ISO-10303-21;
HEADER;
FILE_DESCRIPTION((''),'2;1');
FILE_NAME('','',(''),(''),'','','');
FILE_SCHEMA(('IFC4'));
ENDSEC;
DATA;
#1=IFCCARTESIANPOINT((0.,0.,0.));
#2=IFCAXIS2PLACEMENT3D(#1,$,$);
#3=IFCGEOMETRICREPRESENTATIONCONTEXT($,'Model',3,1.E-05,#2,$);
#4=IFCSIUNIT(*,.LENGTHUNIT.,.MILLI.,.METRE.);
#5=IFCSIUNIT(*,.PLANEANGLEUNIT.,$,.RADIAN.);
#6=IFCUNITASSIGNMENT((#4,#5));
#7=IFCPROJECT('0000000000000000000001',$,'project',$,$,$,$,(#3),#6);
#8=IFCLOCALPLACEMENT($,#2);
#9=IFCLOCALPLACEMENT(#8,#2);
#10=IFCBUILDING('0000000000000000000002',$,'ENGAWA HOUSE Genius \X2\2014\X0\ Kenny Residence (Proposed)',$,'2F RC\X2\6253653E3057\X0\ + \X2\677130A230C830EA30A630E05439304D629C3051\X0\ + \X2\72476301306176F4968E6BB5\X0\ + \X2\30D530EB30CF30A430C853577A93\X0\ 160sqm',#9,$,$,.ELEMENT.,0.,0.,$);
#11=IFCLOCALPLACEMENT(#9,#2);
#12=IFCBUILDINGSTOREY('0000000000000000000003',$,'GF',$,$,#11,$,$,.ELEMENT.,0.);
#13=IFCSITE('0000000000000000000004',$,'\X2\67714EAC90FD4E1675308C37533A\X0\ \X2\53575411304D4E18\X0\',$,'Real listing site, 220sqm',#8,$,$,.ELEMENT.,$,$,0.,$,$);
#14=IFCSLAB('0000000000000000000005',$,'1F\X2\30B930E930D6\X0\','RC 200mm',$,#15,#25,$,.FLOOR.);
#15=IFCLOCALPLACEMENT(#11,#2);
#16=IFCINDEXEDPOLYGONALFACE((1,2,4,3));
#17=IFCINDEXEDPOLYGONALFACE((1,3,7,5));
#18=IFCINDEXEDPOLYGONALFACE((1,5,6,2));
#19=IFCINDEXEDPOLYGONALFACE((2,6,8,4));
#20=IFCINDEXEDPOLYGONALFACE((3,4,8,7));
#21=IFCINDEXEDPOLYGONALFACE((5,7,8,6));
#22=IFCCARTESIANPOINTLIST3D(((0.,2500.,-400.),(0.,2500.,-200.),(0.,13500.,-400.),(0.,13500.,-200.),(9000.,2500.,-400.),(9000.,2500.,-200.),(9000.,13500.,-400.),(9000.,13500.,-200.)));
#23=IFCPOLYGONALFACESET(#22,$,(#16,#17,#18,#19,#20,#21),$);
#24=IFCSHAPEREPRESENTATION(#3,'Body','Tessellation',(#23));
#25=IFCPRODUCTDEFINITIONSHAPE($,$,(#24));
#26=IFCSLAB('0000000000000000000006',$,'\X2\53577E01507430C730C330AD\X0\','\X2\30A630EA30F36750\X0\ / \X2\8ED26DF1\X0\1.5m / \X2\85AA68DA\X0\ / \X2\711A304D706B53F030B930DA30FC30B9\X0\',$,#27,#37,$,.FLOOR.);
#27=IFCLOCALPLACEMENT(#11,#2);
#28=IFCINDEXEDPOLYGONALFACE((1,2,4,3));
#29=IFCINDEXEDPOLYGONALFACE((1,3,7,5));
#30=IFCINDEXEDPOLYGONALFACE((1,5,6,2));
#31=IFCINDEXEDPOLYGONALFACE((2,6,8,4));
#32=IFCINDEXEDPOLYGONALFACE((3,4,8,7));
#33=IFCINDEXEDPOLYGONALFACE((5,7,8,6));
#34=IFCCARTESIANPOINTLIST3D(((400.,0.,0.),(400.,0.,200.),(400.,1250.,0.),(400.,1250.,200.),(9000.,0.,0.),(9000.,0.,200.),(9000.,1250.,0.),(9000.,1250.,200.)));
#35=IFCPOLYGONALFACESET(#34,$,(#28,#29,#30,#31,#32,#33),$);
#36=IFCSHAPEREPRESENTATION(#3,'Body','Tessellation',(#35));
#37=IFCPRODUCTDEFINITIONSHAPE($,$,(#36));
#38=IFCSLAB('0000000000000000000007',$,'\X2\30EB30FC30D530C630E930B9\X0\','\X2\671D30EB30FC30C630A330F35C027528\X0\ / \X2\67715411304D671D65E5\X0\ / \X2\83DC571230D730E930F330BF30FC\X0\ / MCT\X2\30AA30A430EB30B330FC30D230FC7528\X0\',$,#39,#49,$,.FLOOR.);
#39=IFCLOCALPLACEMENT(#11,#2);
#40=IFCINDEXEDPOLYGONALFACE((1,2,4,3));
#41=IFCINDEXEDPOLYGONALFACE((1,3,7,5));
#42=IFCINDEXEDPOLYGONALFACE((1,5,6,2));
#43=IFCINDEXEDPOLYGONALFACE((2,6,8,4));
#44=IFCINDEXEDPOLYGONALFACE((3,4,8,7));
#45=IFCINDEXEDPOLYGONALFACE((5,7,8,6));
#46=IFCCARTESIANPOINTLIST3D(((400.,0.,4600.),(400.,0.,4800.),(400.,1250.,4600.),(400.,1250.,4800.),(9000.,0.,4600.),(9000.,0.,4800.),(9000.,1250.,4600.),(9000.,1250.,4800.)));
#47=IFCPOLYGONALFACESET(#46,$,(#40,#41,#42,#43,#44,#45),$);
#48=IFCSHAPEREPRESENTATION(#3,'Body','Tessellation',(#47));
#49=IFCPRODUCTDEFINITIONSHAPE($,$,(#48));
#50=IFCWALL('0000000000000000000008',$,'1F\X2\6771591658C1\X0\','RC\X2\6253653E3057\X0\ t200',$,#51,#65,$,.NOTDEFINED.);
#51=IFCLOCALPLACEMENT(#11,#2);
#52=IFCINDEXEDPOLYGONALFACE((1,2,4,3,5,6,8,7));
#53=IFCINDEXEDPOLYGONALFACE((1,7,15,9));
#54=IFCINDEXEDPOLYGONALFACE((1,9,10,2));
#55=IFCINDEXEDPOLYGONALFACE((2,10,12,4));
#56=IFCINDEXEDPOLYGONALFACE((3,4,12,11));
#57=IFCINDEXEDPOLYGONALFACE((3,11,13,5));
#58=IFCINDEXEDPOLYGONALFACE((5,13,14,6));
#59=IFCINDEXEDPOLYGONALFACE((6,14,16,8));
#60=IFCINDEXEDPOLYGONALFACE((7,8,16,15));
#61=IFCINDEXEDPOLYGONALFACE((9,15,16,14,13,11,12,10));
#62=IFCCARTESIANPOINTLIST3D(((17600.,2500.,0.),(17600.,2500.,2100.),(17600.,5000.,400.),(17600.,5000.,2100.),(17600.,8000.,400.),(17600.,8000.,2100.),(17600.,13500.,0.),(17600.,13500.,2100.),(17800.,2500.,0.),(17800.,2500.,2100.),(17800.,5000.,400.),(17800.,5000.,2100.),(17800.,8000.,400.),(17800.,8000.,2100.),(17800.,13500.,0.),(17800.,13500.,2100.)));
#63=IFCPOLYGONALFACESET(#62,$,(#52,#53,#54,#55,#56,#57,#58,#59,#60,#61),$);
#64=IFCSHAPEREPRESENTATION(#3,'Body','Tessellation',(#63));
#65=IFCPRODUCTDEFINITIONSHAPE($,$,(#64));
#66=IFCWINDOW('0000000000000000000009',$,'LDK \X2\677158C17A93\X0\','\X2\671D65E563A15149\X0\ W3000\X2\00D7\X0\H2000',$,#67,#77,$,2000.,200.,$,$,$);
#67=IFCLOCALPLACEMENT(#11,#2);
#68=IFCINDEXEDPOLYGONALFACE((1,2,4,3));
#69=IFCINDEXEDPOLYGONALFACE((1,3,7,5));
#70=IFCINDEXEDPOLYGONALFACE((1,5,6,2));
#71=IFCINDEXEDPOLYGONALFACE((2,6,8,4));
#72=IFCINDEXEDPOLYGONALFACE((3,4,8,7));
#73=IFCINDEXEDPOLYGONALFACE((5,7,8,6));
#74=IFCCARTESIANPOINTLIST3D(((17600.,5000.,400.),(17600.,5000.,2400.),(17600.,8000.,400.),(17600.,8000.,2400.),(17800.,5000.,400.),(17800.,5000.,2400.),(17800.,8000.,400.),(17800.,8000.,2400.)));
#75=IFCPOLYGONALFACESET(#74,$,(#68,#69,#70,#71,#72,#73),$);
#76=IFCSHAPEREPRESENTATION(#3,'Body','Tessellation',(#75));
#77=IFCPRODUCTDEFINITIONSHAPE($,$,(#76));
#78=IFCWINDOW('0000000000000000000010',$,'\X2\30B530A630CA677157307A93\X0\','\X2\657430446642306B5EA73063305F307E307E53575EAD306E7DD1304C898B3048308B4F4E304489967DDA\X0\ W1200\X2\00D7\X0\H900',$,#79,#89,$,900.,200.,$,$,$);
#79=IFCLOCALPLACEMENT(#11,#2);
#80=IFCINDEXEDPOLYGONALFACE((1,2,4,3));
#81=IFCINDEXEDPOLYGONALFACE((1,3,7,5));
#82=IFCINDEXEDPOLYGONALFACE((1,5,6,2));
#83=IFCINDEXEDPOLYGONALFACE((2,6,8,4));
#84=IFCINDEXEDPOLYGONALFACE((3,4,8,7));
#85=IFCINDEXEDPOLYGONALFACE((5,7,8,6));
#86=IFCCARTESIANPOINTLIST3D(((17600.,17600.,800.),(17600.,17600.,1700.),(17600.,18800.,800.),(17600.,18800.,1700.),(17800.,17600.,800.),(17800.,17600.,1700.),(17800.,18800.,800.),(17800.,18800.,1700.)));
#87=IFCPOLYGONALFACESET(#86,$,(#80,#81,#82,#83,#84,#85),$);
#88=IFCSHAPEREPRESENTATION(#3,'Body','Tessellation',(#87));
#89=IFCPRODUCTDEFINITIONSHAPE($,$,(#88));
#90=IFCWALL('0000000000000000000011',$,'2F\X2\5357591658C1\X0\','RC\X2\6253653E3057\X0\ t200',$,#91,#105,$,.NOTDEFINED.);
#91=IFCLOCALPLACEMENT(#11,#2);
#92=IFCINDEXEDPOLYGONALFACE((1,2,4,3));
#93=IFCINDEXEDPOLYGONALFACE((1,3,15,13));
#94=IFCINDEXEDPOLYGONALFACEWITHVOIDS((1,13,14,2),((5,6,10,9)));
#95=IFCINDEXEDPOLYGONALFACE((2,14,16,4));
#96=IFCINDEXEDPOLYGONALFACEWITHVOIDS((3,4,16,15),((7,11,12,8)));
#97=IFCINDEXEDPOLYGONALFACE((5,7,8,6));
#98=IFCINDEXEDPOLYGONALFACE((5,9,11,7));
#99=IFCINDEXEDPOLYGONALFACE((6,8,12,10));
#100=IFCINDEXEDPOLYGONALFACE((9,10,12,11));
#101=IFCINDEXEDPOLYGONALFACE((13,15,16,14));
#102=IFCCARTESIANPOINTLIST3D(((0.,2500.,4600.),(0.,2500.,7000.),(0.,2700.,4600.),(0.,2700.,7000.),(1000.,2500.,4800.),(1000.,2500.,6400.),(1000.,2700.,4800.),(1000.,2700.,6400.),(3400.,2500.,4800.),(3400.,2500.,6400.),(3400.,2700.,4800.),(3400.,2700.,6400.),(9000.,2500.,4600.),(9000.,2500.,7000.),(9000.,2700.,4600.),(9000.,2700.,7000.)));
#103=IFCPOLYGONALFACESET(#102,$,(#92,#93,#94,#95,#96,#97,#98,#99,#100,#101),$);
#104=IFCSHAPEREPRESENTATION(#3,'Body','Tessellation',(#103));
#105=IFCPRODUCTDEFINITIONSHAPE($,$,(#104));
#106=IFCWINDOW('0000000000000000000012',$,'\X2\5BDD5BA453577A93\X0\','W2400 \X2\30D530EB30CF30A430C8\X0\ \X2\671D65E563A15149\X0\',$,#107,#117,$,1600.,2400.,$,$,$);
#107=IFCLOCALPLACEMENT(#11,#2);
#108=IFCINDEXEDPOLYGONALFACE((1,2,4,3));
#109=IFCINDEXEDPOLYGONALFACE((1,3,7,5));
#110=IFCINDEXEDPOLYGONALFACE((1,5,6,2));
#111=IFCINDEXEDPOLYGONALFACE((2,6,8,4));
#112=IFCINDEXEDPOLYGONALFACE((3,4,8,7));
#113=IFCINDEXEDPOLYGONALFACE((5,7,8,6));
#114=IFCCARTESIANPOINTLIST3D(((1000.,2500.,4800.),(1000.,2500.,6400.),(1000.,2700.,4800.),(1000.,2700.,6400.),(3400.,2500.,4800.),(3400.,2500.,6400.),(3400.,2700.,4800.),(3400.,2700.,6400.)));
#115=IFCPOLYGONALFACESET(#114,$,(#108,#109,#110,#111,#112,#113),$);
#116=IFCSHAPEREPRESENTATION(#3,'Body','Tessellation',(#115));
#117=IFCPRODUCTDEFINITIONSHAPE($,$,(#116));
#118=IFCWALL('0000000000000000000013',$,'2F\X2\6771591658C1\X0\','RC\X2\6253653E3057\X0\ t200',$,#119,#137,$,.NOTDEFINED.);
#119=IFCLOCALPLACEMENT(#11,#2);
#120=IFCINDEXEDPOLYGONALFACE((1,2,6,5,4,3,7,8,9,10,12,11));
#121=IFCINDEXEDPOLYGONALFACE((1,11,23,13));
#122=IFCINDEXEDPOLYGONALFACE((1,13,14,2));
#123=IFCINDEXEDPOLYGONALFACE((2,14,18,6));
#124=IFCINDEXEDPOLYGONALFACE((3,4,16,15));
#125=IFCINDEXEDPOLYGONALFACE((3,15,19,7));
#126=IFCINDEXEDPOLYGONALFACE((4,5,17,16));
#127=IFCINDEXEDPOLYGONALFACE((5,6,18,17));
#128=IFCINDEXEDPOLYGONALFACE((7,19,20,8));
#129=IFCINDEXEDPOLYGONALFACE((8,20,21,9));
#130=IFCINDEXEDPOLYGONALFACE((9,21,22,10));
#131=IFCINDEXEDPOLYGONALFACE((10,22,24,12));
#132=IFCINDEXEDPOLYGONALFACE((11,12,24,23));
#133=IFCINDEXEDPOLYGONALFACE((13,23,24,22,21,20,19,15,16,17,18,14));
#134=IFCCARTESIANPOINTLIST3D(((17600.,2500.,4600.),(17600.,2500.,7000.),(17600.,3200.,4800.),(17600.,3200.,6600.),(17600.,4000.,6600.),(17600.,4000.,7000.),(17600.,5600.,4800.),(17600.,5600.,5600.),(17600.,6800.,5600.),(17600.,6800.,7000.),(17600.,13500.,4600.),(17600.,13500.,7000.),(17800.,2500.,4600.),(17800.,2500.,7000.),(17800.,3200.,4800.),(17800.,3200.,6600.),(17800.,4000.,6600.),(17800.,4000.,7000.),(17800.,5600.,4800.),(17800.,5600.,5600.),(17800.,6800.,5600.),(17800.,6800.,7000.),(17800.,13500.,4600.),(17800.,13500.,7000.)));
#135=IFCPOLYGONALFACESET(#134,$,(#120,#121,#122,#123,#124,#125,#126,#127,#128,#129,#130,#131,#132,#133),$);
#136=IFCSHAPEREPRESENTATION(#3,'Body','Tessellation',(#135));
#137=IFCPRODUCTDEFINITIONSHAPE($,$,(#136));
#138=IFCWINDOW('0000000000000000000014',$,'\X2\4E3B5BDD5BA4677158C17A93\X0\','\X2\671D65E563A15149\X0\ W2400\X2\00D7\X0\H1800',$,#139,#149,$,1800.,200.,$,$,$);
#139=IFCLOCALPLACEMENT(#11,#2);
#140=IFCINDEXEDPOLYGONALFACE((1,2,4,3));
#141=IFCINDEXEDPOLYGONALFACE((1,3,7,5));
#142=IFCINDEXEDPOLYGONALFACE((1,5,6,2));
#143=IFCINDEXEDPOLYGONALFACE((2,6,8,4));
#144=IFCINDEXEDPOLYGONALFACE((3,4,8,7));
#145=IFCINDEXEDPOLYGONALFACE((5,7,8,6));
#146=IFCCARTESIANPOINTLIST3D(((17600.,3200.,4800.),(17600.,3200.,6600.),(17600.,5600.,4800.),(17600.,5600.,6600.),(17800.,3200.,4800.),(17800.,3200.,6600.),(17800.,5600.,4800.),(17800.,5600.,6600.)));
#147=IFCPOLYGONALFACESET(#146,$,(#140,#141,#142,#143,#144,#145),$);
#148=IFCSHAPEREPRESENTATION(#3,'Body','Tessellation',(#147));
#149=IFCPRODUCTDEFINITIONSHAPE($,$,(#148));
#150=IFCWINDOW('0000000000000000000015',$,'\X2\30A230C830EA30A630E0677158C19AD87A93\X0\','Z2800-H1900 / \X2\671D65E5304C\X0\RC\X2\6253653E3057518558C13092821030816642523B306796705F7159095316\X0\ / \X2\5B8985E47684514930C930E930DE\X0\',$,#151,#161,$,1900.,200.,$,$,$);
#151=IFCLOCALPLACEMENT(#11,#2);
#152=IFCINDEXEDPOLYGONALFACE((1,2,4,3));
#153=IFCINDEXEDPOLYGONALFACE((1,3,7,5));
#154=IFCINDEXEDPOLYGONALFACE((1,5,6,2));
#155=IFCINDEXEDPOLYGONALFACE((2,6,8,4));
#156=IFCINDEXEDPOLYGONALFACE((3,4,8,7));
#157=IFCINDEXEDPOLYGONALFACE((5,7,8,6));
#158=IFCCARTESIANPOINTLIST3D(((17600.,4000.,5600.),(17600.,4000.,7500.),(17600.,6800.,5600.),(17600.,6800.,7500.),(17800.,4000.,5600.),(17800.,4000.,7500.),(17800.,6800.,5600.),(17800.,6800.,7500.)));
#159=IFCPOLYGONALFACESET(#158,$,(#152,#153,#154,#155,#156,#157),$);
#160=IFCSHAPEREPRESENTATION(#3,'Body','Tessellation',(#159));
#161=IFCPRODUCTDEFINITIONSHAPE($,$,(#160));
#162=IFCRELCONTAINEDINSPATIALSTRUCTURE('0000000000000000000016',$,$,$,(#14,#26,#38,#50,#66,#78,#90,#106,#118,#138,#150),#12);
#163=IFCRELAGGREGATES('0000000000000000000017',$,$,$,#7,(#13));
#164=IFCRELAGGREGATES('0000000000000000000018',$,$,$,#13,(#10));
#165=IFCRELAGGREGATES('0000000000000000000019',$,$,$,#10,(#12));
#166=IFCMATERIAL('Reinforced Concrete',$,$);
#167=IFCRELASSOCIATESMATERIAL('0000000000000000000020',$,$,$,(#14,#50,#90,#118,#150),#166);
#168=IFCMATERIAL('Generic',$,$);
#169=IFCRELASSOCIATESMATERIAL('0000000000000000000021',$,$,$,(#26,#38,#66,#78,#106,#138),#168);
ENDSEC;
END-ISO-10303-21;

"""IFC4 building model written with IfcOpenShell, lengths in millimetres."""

from ifc_helpers import new_model, si_unit, frame, frame_2d, origin, place, context, project, spatial, rectangle, extrude, material, element, fill, save


model = new_model("IFC4")

# Units and contexts
model_context = context("Model", 3, precision=1e-05, world=origin())
ifc_project = project(units=[si_unit("LENGTHUNIT", "METRE", prefix="MILLI"), si_unit("PLANEANGLEUNIT", "RADIAN")], contexts=[model_context])

# Site, building, storey
site_placement = place(None, origin())
site = spatial("IfcSite", under=ifc_project, at=site_placement, Name="東京都世田谷区 南向き丘", ObjectType="Real listing site, 220sqm", CompositionType="ELEMENT", RefElevation=0.0)
building_placement = place(site_placement, origin())
building = spatial("IfcBuilding", under=site, at=building_placement, Name="ENGAWA HOUSE Genius — Kenny Residence (Proposed)", ObjectType="2F RC打放し + 東アトリウム吹き抜け + 片持ち直階段 + フルハイト南窓 160sqm", CompositionType="ELEMENT", ElevationOfRefHeight=0.0, ElevationOfTerrain=0.0)
storey_placement = place(building_placement, origin())
storey = spatial("IfcBuildingStorey", under=building, at=storey_placement, Name="GF", CompositionType="ELEMENT", Elevation=0.0)

# Slabs
ifc_material_1 = material(Name="Reinforced Concrete")
slab_1_placement = place(storey_placement, frame((0.0, 1250.0, -200.0)))
element("IfcSlab", 1, at=slab_1_placement, inside=storey, material=ifc_material_1, Name="1Fスラブ", Description="RC 200mm", PredefinedType="FLOOR", context=model_context, shape_type="SweptSolid", body=[
    extrude(rectangle(XDim=9000.0, YDim=11000.0, at=frame_2d((4500.0, 5500.0))), frame((0.0, 1250.0, -200.0)), (0.0, 0.0, 1.0), 200.0),
])
ifc_material_2 = material(Name="Generic")
slab_2_placement = place(storey_placement, frame((200.0, 0.0, 0.0)))
element("IfcSlab", 2, at=slab_2_placement, inside=storey, material=ifc_material_2, Name="南縁側デッキ", Description="ウリン材 / 軒深1.5m / 薪棚 / 焚き火台スペース", PredefinedType="FLOOR", context=model_context, shape_type="SweptSolid", body=[
    extrude(rectangle(XDim=8600.0, YDim=1250.0, at=frame_2d((4300.0, 625.0))), frame((200.0, 0.0, 0.0)), (0.0, 0.0, 1.0), 200.0),
])
slab_3_placement = place(storey_placement, frame((200.0, 0.0, 2300.0)))
element("IfcSlab", 3, at=slab_3_placement, inside=storey, material=ifc_material_2, Name="ルーフテラス", Description="朝ルーティン専用 / 東向き朝日 / 菜園プランター / MCTオイルコーヒー用", PredefinedType="FLOOR", context=model_context, shape_type="SweptSolid", body=[
    extrude(rectangle(XDim=8600.0, YDim=1250.0, at=frame_2d((4300.0, 625.0))), frame((200.0, 0.0, 2300.0)), (0.0, 0.0, 1.0), 200.0),
])

# Wall, openings, windows
wall_1_placement = place(storey_placement, frame((8800.0, 1250.0, 0.0)))
wall_1 = element("IfcWall", 4, at=wall_1_placement, inside=storey, material=ifc_material_1, Name="1F東外壁", Description="RC打放し t200", PredefinedType="NOTDEFINED", context=model_context, shape_type="SweptSolid", body=[
    extrude(rectangle(XDim=200.0, YDim=11000.0, at=frame_2d((100.0, 5500.0))), frame((8800.0, 1250.0, 0.0)), (0.0, 0.0, 1.0), 2100.0),
])
opening_1_placement = place(storey_placement, frame((8800.0, 2500.0, 200.0)))
opening_1 = element("IfcOpeningElement", 5, at=opening_1_placement, cuts=wall_1, PredefinedType="NOTDEFINED", context=model_context, shape_type="SweptSolid", body=[
    extrude(rectangle(XDim=200.0, YDim=3000.0, at=frame_2d((100.0, 1500.0))), frame((8800.0, 2500.0, 200.0)), (0.0, 0.0, 1.0), 2000.0),
])
opening_2_placement = place(storey_placement, frame((8800.0, 8800.0, 400.0)))
opening_2 = element("IfcOpeningElement", 6, at=opening_2_placement, cuts=wall_1, PredefinedType="NOTDEFINED", context=model_context, shape_type="SweptSolid", body=[
    extrude(rectangle(XDim=200.0, YDim=1200.0, at=frame_2d((100.0, 600.0))), frame((8800.0, 8800.0, 400.0)), (0.0, 0.0, 1.0), 900.0),
])
window_1_placement = place(storey_placement, frame((8800.0, 2500.0, 200.0)))
window_1 = element("IfcWindow", 7, at=window_1_placement, inside=storey, material=ifc_material_2, Name="LDK 東壁窓", Description="朝日採光 W3000×H2000", OverallHeight=2000.0, OverallWidth=200.0, context=model_context, shape_type="SweptSolid", body=[
    extrude(rectangle(XDim=200.0, YDim=3000.0, at=frame_2d((100.0, 1500.0))), frame((8800.0, 2500.0, 200.0)), (0.0, 0.0, 1.0), 2000.0),
])
fill(opening_1, window_1)
window_2_placement = place(storey_placement, frame((8800.0, 8800.0, 400.0)))
window_2 = element("IfcWindow", 8, at=window_2_placement, inside=storey, material=ifc_material_2, Name="サウナ東地窓", Description="整い時に座ったまま南庭の緑が見える低い視線 W1200×H900", OverallHeight=900.0, OverallWidth=200.0, context=model_context, shape_type="SweptSolid", body=[
    extrude(rectangle(XDim=200.0, YDim=1200.0, at=frame_2d((100.0, 600.0))), frame((8800.0, 8800.0, 400.0)), (0.0, 0.0, 1.0), 900.0),
])
fill(opening_2, window_2)

# Wall, opening, window
wall_2_placement = place(storey_placement, frame((0.0, 1250.0, 2300.0)))
wall_2 = element("IfcWall", 9, at=wall_2_placement, inside=storey, material=ifc_material_1, Name="2F南外壁", Description="RC打放し t200", PredefinedType="NOTDEFINED", context=model_context, shape_type="SweptSolid", body=[
    extrude(rectangle(XDim=9000.0, YDim=200.0, at=frame_2d((4500.0, 100.0))), frame((0.0, 1250.0, 2300.0)), (0.0, 0.0, 1.0), 2400.0),
])
opening_3_placement = place(storey_placement, frame((500.0, 1250.0, 2400.0)))
opening_3 = element("IfcOpeningElement", 10, at=opening_3_placement, cuts=wall_2, PredefinedType="NOTDEFINED", context=model_context, shape_type="SweptSolid", body=[
    extrude(rectangle(XDim=2400.0, YDim=200.0, at=frame_2d((1200.0, 100.0))), frame((500.0, 1250.0, 2400.0)), (0.0, 0.0, 1.0), 1600.0),
])
window_3_placement = place(storey_placement, frame((500.0, 1250.0, 2400.0)))
window_3 = element("IfcWindow", 11, at=window_3_placement, inside=storey, material=ifc_material_2, Name="寝室南窓", Description="W2400 フルハイト 朝日採光", OverallHeight=1600.0, OverallWidth=2400.0, context=model_context, shape_type="SweptSolid", body=[
    extrude(rectangle(XDim=2400.0, YDim=200.0, at=frame_2d((1200.0, 100.0))), frame((500.0, 1250.0, 2400.0)), (0.0, 0.0, 1.0), 1600.0),
])
fill(opening_3, window_3)

# Wall, openings, windows
wall_3_placement = place(storey_placement, frame((8800.0, 1250.0, 2300.0)))
wall_3 = element("IfcWall", 12, at=wall_3_placement, inside=storey, material=ifc_material_1, Name="2F東外壁", Description="RC打放し t200", PredefinedType="NOTDEFINED", context=model_context, shape_type="SweptSolid", body=[
    extrude(rectangle(XDim=200.0, YDim=11000.0, at=frame_2d((100.0, 5500.0))), frame((8800.0, 1250.0, 2300.0)), (0.0, 0.0, 1.0), 2400.0),
])
opening_4_placement = place(storey_placement, frame((8800.0, 1600.0, 2400.0)))
opening_4 = element("IfcOpeningElement", 13, at=opening_4_placement, cuts=wall_3, PredefinedType="NOTDEFINED", context=model_context, shape_type="SweptSolid", body=[
    extrude(rectangle(XDim=200.0, YDim=2400.0, at=frame_2d((100.0, 1200.0))), frame((8800.0, 1600.0, 2400.0)), (0.0, 0.0, 1.0), 1800.0),
])
opening_5_placement = place(storey_placement, frame((8800.0, 2000.0, 2800.0)))
opening_5 = element("IfcOpeningElement", 14, at=opening_5_placement, cuts=wall_3, PredefinedType="NOTDEFINED", context=model_context, shape_type="SweptSolid", body=[
    extrude(rectangle(XDim=200.0, YDim=2800.0, at=frame_2d((100.0, 1400.0))), frame((8800.0, 2000.0, 2800.0)), (0.0, 0.0, 1.0), 1900.0),
])
window_4_placement = place(storey_placement, frame((8800.0, 1600.0, 2400.0)))
window_4 = element("IfcWindow", 15, at=window_4_placement, inside=storey, material=ifc_material_2, Name="主寝室東壁窓", Description="朝日採光 W2400×H1800", OverallHeight=1800.0, OverallWidth=200.0, context=model_context, shape_type="SweptSolid", body=[
    extrude(rectangle(XDim=200.0, YDim=2400.0, at=frame_2d((100.0, 1200.0))), frame((8800.0, 1600.0, 2400.0)), (0.0, 0.0, 1.0), 1800.0),
])
fill(opening_4, window_4)
window_5_placement = place(storey_placement, frame((8800.0, 2000.0, 2800.0)))
window_5 = element("IfcWindow", 16, at=window_5_placement, inside=storey, material=ifc_material_1, Name="アトリウム東壁高窓", Description="Z2800-H1900 / 朝日がRC打放し内壁を舐め時刻で陰影変化 / 安藤的光ドラマ", OverallHeight=1900.0, OverallWidth=200.0, context=model_context, shape_type="SweptSolid", body=[
    extrude(rectangle(XDim=200.0, YDim=2800.0, at=frame_2d((100.0, 1400.0))), frame((8800.0, 2000.0, 2800.0)), (0.0, 0.0, 1.0), 1900.0),
])
fill(opening_5, window_5)

save(model, "model.ifc")
